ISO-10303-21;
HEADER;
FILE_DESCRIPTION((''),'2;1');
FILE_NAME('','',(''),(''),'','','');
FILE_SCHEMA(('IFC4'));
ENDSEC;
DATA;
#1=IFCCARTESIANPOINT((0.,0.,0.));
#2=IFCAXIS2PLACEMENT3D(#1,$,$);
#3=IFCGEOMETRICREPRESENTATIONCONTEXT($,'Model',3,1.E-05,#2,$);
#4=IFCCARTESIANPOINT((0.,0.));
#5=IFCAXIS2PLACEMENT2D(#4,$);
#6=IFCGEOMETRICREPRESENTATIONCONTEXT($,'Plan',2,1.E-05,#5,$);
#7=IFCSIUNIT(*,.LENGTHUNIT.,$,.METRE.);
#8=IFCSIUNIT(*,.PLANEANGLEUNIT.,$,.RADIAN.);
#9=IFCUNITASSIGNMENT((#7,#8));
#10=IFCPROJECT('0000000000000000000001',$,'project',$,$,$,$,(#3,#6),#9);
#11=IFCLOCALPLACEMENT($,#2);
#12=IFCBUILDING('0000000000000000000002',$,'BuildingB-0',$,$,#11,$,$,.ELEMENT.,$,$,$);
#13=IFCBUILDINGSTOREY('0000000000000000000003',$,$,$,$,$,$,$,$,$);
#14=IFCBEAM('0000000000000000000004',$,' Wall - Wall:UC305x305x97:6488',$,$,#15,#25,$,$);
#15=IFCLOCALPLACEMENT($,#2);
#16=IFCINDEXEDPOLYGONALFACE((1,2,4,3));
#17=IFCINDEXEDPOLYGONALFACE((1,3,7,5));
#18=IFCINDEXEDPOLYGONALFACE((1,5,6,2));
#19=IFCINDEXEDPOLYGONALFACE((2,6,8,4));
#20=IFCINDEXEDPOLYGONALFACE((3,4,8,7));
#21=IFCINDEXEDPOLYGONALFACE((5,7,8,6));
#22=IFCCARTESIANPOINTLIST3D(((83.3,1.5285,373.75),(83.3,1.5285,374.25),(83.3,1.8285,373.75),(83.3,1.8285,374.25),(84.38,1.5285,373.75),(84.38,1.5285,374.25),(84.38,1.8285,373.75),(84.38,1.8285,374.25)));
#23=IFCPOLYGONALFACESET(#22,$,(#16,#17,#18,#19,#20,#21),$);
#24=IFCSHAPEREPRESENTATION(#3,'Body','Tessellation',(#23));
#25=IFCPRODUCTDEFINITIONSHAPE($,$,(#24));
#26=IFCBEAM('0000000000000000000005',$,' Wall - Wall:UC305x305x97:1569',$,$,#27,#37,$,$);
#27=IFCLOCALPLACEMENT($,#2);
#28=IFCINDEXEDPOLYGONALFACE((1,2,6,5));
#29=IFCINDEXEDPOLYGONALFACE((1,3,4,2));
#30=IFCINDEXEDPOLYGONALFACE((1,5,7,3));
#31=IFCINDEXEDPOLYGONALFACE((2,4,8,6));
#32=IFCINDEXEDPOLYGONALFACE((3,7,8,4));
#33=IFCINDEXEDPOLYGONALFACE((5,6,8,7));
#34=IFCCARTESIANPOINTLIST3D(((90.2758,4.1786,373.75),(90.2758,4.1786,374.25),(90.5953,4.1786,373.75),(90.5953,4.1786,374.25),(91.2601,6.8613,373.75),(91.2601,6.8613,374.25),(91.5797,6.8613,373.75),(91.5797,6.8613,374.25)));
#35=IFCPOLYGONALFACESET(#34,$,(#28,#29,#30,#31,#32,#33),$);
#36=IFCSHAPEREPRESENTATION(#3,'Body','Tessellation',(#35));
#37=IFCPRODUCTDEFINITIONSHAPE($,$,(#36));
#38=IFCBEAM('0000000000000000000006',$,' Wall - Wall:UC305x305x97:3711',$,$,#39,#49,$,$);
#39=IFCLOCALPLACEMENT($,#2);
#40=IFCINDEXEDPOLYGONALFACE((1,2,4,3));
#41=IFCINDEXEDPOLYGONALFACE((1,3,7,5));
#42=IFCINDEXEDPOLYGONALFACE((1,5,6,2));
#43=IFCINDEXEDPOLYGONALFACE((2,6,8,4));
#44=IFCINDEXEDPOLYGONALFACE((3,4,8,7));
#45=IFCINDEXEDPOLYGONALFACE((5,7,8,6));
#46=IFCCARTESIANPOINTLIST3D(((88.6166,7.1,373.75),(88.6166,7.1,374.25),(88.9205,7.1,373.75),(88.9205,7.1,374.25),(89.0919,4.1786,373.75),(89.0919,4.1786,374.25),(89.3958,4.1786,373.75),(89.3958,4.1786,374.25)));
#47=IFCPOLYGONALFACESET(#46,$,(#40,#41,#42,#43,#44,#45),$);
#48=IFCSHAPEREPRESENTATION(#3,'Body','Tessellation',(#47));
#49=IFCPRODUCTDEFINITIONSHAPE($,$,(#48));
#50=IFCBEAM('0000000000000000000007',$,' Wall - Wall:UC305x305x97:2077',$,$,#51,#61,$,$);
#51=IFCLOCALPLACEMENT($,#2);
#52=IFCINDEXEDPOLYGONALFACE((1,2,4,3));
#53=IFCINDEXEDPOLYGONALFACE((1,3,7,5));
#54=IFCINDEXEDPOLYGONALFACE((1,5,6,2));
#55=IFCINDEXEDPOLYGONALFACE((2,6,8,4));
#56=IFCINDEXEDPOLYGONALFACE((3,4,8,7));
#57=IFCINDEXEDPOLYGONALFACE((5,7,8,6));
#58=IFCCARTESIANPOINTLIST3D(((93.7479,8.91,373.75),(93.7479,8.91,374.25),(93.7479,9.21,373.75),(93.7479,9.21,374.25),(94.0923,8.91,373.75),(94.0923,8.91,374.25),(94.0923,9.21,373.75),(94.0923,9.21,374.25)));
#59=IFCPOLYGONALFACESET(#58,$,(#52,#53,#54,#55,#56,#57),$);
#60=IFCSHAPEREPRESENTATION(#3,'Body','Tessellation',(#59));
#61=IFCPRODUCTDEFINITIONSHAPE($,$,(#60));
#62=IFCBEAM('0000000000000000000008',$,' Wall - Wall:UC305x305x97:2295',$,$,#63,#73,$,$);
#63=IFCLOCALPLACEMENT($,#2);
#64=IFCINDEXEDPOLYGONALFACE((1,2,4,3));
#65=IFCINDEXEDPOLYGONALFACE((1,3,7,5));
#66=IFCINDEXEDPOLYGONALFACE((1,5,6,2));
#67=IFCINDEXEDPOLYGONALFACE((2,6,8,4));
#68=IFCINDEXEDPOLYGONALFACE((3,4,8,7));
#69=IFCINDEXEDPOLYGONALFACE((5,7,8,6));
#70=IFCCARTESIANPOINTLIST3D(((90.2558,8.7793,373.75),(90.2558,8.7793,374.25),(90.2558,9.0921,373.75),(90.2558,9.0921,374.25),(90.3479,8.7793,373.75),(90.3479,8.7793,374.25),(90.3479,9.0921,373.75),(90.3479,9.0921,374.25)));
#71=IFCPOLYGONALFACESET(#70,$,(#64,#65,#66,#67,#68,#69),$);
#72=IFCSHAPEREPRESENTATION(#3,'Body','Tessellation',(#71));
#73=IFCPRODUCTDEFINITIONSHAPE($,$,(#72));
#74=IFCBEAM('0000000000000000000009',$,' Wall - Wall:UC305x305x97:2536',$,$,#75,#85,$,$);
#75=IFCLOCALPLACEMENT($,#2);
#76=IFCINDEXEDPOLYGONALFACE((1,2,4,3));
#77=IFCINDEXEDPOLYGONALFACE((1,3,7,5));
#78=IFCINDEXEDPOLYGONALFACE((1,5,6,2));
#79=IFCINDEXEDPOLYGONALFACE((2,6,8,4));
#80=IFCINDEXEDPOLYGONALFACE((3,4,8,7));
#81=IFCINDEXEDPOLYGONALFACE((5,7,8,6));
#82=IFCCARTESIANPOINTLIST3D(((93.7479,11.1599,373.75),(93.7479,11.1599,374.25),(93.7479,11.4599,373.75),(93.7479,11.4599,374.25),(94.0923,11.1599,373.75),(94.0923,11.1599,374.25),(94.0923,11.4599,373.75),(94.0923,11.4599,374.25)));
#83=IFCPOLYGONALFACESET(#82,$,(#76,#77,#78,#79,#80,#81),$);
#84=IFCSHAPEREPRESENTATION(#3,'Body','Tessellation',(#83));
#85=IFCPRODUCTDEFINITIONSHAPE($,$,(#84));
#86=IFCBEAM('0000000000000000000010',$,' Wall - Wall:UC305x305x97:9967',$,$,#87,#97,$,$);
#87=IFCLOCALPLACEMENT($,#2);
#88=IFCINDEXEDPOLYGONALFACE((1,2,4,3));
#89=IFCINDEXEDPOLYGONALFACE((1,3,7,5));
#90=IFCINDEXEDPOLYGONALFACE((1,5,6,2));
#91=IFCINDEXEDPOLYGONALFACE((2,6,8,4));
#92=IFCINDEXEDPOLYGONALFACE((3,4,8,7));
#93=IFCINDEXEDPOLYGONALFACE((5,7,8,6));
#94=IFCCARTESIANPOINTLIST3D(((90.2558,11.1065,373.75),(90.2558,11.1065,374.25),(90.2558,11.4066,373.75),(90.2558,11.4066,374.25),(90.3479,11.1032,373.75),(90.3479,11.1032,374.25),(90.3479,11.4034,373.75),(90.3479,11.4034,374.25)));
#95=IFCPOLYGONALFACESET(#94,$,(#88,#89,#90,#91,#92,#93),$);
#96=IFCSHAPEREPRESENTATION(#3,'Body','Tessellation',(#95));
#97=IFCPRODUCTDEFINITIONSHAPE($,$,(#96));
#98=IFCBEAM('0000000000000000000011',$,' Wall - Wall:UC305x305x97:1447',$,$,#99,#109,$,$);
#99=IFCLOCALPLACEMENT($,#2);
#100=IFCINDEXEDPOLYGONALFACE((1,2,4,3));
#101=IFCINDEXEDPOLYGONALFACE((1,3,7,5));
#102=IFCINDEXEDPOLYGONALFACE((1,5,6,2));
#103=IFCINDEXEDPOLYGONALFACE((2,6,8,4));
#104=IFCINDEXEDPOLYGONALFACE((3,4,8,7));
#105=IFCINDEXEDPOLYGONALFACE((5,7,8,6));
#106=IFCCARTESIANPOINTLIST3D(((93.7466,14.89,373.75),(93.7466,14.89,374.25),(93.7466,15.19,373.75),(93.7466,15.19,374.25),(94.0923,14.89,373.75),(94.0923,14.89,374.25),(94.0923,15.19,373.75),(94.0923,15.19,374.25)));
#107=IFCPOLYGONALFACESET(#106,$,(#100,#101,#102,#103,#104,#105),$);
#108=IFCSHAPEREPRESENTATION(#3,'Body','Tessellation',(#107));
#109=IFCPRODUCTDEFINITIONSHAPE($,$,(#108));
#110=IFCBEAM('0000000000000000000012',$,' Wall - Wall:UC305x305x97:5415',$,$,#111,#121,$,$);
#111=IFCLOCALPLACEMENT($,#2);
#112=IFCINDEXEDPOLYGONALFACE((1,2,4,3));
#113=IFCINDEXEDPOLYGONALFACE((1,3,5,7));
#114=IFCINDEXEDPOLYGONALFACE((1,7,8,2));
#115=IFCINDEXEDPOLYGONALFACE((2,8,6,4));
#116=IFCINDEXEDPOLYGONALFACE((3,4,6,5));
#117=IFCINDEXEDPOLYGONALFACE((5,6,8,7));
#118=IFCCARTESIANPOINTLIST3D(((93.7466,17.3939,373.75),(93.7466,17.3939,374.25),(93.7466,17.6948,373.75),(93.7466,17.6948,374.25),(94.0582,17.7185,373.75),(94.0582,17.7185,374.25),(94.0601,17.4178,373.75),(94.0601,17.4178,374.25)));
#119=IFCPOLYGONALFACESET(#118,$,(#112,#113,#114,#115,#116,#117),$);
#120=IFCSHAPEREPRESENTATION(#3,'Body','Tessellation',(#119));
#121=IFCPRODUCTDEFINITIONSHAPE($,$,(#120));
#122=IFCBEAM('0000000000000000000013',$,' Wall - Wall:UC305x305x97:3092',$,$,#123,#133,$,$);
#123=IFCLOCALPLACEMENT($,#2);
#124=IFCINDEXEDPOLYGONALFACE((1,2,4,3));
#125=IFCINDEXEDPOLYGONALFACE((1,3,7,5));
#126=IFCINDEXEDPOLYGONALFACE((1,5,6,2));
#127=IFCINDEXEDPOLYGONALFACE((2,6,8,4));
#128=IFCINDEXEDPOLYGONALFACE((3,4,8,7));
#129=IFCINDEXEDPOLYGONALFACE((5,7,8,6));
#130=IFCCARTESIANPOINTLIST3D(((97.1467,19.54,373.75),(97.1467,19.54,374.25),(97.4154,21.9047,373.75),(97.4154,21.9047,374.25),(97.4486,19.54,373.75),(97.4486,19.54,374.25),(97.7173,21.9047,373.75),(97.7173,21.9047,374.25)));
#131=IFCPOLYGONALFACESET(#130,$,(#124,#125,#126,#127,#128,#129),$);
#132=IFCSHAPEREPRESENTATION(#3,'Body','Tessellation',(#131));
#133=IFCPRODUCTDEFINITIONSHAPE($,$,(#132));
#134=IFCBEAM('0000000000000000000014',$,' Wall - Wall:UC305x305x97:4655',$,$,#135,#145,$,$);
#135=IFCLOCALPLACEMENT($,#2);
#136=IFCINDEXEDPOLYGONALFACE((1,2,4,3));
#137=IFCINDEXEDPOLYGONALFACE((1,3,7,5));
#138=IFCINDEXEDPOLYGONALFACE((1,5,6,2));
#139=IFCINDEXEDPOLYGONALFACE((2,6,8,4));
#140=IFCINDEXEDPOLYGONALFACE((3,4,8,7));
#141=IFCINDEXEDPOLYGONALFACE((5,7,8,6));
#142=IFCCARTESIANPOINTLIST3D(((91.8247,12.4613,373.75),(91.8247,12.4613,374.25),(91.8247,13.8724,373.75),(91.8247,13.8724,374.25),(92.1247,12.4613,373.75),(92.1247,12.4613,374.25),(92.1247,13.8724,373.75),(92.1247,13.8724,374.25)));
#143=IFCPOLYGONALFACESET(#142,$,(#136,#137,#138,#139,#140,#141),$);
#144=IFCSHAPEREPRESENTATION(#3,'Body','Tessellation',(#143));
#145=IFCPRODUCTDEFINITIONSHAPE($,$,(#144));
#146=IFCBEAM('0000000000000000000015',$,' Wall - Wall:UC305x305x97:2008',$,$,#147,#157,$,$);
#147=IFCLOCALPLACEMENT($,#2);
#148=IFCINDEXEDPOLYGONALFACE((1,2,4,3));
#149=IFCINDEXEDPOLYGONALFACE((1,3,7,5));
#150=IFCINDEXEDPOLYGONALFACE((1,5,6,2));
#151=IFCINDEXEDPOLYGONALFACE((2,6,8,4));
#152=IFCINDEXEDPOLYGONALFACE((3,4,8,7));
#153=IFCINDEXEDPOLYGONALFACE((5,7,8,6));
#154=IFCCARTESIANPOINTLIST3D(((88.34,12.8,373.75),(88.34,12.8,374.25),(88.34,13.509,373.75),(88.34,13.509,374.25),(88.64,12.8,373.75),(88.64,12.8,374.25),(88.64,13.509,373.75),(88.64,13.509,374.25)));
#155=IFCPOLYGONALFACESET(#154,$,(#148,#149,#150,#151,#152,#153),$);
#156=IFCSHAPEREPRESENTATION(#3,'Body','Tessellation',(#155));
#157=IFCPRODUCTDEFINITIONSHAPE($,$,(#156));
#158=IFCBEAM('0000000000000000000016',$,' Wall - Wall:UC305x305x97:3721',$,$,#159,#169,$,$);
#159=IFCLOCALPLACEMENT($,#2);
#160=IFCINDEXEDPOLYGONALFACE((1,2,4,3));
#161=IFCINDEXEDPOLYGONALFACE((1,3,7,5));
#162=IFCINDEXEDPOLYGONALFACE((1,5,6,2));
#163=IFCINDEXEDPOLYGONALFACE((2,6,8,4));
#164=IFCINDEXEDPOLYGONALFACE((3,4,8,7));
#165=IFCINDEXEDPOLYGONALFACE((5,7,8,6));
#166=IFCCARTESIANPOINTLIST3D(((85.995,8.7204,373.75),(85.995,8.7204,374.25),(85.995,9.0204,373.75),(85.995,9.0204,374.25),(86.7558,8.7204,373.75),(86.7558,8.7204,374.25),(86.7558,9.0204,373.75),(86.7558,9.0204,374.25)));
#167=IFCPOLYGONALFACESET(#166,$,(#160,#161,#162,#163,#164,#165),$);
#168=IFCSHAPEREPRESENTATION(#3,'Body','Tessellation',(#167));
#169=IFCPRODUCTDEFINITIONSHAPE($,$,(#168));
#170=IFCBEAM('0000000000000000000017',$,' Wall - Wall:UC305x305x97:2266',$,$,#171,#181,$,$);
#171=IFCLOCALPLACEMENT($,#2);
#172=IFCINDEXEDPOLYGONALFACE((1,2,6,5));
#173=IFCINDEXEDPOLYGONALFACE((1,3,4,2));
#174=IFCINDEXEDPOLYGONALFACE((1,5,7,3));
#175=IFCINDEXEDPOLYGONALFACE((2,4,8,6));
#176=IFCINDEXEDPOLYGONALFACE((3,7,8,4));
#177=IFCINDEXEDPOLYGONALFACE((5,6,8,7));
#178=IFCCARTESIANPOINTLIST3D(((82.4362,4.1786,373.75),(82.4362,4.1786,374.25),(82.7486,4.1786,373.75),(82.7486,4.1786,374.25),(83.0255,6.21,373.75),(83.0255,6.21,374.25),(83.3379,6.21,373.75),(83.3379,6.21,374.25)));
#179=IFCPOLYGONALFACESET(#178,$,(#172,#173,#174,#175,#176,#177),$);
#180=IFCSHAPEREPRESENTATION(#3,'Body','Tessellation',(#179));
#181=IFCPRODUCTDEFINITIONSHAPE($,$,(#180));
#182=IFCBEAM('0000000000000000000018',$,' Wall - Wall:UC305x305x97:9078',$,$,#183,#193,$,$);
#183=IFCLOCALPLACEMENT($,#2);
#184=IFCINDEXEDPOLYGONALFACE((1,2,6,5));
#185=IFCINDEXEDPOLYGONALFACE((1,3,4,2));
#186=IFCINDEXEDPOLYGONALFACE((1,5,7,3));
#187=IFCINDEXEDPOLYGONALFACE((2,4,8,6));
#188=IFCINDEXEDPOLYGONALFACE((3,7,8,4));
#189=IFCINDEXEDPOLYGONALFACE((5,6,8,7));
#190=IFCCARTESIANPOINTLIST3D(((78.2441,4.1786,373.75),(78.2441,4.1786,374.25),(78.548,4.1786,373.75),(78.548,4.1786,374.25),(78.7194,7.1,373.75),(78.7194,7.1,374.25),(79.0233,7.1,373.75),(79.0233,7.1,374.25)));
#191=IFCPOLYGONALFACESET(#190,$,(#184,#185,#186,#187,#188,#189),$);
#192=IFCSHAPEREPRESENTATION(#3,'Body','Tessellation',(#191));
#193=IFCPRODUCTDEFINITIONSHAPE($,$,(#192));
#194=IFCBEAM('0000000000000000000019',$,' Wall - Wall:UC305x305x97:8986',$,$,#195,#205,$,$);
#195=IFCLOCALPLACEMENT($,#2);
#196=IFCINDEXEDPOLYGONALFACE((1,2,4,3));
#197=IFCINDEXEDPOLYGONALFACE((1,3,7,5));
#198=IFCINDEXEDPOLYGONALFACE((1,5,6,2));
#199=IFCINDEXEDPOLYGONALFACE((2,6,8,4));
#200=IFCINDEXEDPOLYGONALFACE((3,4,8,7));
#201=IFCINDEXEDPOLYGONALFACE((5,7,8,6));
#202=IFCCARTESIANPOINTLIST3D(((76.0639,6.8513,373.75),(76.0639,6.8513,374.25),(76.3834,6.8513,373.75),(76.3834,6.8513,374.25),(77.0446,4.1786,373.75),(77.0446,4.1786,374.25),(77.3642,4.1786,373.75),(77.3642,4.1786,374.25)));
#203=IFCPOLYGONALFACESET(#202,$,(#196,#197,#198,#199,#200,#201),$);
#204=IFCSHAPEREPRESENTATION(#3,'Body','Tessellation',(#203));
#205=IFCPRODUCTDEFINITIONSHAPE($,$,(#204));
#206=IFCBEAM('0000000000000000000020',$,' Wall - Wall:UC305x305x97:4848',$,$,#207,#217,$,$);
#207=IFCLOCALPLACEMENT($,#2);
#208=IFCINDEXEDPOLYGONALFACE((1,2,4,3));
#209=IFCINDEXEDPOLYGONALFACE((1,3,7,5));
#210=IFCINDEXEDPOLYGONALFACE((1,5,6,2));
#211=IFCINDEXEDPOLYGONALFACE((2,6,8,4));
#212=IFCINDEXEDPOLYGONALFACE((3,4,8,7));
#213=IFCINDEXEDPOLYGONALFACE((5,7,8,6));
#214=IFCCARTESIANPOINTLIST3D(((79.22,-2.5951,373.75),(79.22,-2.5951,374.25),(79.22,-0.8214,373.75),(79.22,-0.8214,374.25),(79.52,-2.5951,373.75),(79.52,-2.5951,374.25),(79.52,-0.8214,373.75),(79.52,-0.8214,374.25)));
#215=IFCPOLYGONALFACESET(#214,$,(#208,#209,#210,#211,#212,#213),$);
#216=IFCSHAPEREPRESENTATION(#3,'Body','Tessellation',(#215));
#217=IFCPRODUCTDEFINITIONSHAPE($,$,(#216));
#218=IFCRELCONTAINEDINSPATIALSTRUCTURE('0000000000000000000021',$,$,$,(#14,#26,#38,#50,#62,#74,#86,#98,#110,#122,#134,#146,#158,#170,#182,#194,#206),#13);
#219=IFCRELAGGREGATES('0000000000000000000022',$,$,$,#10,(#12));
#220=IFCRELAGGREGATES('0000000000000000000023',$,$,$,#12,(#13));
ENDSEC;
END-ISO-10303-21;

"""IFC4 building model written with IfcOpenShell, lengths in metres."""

from ifc_helpers import new_model, si_unit, origin, origin_2d, place, context, project, spatial, polyline, outline, extrude, element, save


model = new_model("IFC4")

# Units and contexts
model_context = context("Model", 3, precision=1e-05, world=origin())
plan_context = context("Plan", 2, precision=1e-05, world=origin_2d())
ifc_project = project(units=[si_unit("LENGTHUNIT", "METRE"), si_unit("PLANEANGLEUNIT", "RADIAN")], contexts=[model_context, plan_context])

# Building, storey
building_placement = place(None, origin())
building = spatial("IfcBuilding", under=ifc_project, at=building_placement, Name="BuildingB-0", CompositionType="ELEMENT")
storey = spatial("IfcBuildingStorey", under=building)

# Beams
element("IfcBeam", 1, inside=storey, Name=" Wall - Wall:UC305x305x97:6488", context=model_context, shape_type="SweptSolid", body=[
    extrude(outline(polyline([(84.38, 1.5285, 373.75), (84.38, 1.8285, 373.75), (83.3, 1.8285, 373.75), (83.3, 1.5285, 373.75), (84.38, 1.5285, 373.75)])), None, (0.0, 0.0, 1.0), 0.5),
])
element("IfcBeam", 2, inside=storey, Name=" Wall - Wall:UC305x305x97:1569", context=model_context, shape_type="SweptSolid", body=[
    extrude(outline(polyline([(90.5953, 4.1786, 373.75), (90.2758, 4.1786, 373.75), (91.2601, 6.8613, 373.75), (91.5797, 6.8613, 373.75), (90.5953, 4.1786, 373.75)])), None, (0.0, 0.0, 1.0), 0.5),
])
element("IfcBeam", 3, inside=storey, Name=" Wall - Wall:UC305x305x97:3711", context=model_context, shape_type="SweptSolid", body=[
    extrude(outline(polyline([(89.3958, 4.1786, 373.75), (89.0919, 4.1786, 373.75), (88.6166, 7.1, 373.75), (88.9205, 7.1, 373.75), (89.3958, 4.1786, 373.75)])), None, (0.0, 0.0, 1.0), 0.5),
])
element("IfcBeam", 4, inside=storey, Name=" Wall - Wall:UC305x305x97:2077", context=model_context, shape_type="SweptSolid", body=[
    extrude(outline(polyline([(94.0923, 8.91, 373.75), (94.0923, 9.21, 373.75), (93.7479, 9.21, 373.75), (93.7479, 8.91, 373.75), (94.0923, 8.91, 373.75)])), None, (0.0, 0.0, 1.0), 0.5),
])
element("IfcBeam", 5, inside=storey, Name=" Wall - Wall:UC305x305x97:2295", context=model_context, shape_type="SweptSolid", body=[
    extrude(outline(polyline([(90.3479, 8.7793, 373.75), (90.2558, 8.7793, 373.75), (90.2558, 9.0921, 373.75), (90.3479, 9.0921, 373.75), (90.3479, 8.7793, 373.75)])), None, (0.0, 0.0, 1.0), 0.5),
])
element("IfcBeam", 6, inside=storey, Name=" Wall - Wall:UC305x305x97:2536", context=model_context, shape_type="SweptSolid", body=[
    extrude(outline(polyline([(94.0923, 11.1599, 373.75), (93.7479, 11.1599, 373.75), (93.7479, 11.4599, 373.75), (94.0923, 11.4599, 373.75), (94.0923, 11.1599, 373.75)])), None, (0.0, 0.0, 1.0), 0.5),
])
element("IfcBeam", 7, inside=storey, Name=" Wall - Wall:UC305x305x97:9967", context=model_context, shape_type="SweptSolid", body=[
    extrude(outline(polyline([(90.3479, 11.1032, 373.75), (90.2558, 11.1065, 373.75), (90.2558, 11.4066, 373.75), (90.3479, 11.4034, 373.75), (90.3479, 11.1032, 373.75)])), None, (0.0, 0.0, 1.0), 0.5),
])
element("IfcBeam", 8, inside=storey, Name=" Wall - Wall:UC305x305x97:1447", context=model_context, shape_type="SweptSolid", body=[
    extrude(outline(polyline([(94.0923, 15.19, 373.75), (93.7466, 15.19, 373.75), (93.7466, 14.89, 373.75), (94.0923, 14.89, 373.75), (94.0923, 15.19, 373.75)])), None, (0.0, 0.0, 1.0), 0.5),
])
element("IfcBeam", 9, inside=storey, Name=" Wall - Wall:UC305x305x97:5415", context=model_context, shape_type="SweptSolid", body=[
    extrude(outline(polyline([(94.0601, 17.4178, 373.75), (93.7466, 17.3939, 373.75), (93.7466, 17.6948, 373.75), (94.0582, 17.7185, 373.75), (94.0601, 17.4178, 373.75)])), None, (0.0, 0.0, 1.0), 0.5),
])
element("IfcBeam", 10, inside=storey, Name=" Wall - Wall:UC305x305x97:3092", context=model_context, shape_type="SweptSolid", body=[
    extrude(outline(polyline([(97.4486, 19.54, 373.75), (97.1467, 19.54, 373.75), (97.4154, 21.9047, 373.75), (97.7173, 21.9047, 373.75), (97.4486, 19.54, 373.75)])), None, (0.0, 0.0, 1.0), 0.5),
])
element("IfcBeam", 11, inside=storey, Name=" Wall - Wall:UC305x305x97:4655", context=model_context, shape_type="SweptSolid", body=[
    extrude(outline(polyline([(92.1247, 12.4613, 373.75), (91.8247, 12.4613, 373.75), (91.8247, 13.8724, 373.75), (92.1247, 13.8724, 373.75), (92.1247, 12.4613, 373.75)])), None, (0.0, 0.0, 1.0), 0.5),
])
element("IfcBeam", 12, inside=storey, Name=" Wall - Wall:UC305x305x97:2008", context=model_context, shape_type="SweptSolid", body=[
    extrude(outline(polyline([(88.64, 12.8, 373.75), (88.34, 12.8, 373.75), (88.34, 13.509, 373.75), (88.64, 13.509, 373.75), (88.64, 12.8, 373.75)])), None, (0.0, 0.0, 1.0), 0.5),
])
element("IfcBeam", 13, inside=storey, Name=" Wall - Wall:UC305x305x97:3721", context=model_context, shape_type="SweptSolid", body=[
    extrude(outline(polyline([(86.7558, 8.7204, 373.75), (85.995, 8.7204, 373.75), (85.995, 9.0204, 373.75), (86.7558, 9.0204, 373.75), (86.7558, 8.7204, 373.75)])), None, (0.0, 0.0, 1.0), 0.5),
])
element("IfcBeam", 14, inside=storey, Name=" Wall - Wall:UC305x305x97:2266", context=model_context, shape_type="SweptSolid", body=[
    extrude(outline(polyline([(82.7486, 4.1786, 373.75), (82.4362, 4.1786, 373.75), (83.0255, 6.21, 373.75), (83.3379, 6.21, 373.75), (82.7486, 4.1786, 373.75)])), None, (0.0, 0.0, 1.0), 0.5),
])
element("IfcBeam", 15, inside=storey, Name=" Wall - Wall:UC305x305x97:9078", context=model_context, shape_type="SweptSolid", body=[
    extrude(outline(polyline([(78.548, 4.1786, 373.75), (78.2441, 4.1786, 373.75), (78.7194, 7.1, 373.75), (79.0233, 7.1, 373.75), (78.548, 4.1786, 373.75)])), None, (0.0, 0.0, 1.0), 0.5),
])
element("IfcBeam", 16, inside=storey, Name=" Wall - Wall:UC305x305x97:8986", context=model_context, shape_type="SweptSolid", body=[
    extrude(outline(polyline([(77.3642, 4.1786, 373.75), (77.0446, 4.1786, 373.75), (76.0639, 6.8513, 373.75), (76.3834, 6.8513, 373.75), (77.3642, 4.1786, 373.75)])), None, (0.0, 0.0, 1.0), 0.5),
])
element("IfcBeam", 17, inside=storey, Name=" Wall - Wall:UC305x305x97:4848", context=model_context, shape_type="SweptSolid", body=[
    extrude(outline(polyline([(79.52, -2.5951, 373.75), (79.22, -2.5951, 373.75), (79.22, -0.8214, 373.75), (79.52, -0.8214, 373.75), (79.52, -2.5951, 373.75)])), None, (0.0, 0.0, 1.0), 0.5),
])

save(model, "model.ifc")
